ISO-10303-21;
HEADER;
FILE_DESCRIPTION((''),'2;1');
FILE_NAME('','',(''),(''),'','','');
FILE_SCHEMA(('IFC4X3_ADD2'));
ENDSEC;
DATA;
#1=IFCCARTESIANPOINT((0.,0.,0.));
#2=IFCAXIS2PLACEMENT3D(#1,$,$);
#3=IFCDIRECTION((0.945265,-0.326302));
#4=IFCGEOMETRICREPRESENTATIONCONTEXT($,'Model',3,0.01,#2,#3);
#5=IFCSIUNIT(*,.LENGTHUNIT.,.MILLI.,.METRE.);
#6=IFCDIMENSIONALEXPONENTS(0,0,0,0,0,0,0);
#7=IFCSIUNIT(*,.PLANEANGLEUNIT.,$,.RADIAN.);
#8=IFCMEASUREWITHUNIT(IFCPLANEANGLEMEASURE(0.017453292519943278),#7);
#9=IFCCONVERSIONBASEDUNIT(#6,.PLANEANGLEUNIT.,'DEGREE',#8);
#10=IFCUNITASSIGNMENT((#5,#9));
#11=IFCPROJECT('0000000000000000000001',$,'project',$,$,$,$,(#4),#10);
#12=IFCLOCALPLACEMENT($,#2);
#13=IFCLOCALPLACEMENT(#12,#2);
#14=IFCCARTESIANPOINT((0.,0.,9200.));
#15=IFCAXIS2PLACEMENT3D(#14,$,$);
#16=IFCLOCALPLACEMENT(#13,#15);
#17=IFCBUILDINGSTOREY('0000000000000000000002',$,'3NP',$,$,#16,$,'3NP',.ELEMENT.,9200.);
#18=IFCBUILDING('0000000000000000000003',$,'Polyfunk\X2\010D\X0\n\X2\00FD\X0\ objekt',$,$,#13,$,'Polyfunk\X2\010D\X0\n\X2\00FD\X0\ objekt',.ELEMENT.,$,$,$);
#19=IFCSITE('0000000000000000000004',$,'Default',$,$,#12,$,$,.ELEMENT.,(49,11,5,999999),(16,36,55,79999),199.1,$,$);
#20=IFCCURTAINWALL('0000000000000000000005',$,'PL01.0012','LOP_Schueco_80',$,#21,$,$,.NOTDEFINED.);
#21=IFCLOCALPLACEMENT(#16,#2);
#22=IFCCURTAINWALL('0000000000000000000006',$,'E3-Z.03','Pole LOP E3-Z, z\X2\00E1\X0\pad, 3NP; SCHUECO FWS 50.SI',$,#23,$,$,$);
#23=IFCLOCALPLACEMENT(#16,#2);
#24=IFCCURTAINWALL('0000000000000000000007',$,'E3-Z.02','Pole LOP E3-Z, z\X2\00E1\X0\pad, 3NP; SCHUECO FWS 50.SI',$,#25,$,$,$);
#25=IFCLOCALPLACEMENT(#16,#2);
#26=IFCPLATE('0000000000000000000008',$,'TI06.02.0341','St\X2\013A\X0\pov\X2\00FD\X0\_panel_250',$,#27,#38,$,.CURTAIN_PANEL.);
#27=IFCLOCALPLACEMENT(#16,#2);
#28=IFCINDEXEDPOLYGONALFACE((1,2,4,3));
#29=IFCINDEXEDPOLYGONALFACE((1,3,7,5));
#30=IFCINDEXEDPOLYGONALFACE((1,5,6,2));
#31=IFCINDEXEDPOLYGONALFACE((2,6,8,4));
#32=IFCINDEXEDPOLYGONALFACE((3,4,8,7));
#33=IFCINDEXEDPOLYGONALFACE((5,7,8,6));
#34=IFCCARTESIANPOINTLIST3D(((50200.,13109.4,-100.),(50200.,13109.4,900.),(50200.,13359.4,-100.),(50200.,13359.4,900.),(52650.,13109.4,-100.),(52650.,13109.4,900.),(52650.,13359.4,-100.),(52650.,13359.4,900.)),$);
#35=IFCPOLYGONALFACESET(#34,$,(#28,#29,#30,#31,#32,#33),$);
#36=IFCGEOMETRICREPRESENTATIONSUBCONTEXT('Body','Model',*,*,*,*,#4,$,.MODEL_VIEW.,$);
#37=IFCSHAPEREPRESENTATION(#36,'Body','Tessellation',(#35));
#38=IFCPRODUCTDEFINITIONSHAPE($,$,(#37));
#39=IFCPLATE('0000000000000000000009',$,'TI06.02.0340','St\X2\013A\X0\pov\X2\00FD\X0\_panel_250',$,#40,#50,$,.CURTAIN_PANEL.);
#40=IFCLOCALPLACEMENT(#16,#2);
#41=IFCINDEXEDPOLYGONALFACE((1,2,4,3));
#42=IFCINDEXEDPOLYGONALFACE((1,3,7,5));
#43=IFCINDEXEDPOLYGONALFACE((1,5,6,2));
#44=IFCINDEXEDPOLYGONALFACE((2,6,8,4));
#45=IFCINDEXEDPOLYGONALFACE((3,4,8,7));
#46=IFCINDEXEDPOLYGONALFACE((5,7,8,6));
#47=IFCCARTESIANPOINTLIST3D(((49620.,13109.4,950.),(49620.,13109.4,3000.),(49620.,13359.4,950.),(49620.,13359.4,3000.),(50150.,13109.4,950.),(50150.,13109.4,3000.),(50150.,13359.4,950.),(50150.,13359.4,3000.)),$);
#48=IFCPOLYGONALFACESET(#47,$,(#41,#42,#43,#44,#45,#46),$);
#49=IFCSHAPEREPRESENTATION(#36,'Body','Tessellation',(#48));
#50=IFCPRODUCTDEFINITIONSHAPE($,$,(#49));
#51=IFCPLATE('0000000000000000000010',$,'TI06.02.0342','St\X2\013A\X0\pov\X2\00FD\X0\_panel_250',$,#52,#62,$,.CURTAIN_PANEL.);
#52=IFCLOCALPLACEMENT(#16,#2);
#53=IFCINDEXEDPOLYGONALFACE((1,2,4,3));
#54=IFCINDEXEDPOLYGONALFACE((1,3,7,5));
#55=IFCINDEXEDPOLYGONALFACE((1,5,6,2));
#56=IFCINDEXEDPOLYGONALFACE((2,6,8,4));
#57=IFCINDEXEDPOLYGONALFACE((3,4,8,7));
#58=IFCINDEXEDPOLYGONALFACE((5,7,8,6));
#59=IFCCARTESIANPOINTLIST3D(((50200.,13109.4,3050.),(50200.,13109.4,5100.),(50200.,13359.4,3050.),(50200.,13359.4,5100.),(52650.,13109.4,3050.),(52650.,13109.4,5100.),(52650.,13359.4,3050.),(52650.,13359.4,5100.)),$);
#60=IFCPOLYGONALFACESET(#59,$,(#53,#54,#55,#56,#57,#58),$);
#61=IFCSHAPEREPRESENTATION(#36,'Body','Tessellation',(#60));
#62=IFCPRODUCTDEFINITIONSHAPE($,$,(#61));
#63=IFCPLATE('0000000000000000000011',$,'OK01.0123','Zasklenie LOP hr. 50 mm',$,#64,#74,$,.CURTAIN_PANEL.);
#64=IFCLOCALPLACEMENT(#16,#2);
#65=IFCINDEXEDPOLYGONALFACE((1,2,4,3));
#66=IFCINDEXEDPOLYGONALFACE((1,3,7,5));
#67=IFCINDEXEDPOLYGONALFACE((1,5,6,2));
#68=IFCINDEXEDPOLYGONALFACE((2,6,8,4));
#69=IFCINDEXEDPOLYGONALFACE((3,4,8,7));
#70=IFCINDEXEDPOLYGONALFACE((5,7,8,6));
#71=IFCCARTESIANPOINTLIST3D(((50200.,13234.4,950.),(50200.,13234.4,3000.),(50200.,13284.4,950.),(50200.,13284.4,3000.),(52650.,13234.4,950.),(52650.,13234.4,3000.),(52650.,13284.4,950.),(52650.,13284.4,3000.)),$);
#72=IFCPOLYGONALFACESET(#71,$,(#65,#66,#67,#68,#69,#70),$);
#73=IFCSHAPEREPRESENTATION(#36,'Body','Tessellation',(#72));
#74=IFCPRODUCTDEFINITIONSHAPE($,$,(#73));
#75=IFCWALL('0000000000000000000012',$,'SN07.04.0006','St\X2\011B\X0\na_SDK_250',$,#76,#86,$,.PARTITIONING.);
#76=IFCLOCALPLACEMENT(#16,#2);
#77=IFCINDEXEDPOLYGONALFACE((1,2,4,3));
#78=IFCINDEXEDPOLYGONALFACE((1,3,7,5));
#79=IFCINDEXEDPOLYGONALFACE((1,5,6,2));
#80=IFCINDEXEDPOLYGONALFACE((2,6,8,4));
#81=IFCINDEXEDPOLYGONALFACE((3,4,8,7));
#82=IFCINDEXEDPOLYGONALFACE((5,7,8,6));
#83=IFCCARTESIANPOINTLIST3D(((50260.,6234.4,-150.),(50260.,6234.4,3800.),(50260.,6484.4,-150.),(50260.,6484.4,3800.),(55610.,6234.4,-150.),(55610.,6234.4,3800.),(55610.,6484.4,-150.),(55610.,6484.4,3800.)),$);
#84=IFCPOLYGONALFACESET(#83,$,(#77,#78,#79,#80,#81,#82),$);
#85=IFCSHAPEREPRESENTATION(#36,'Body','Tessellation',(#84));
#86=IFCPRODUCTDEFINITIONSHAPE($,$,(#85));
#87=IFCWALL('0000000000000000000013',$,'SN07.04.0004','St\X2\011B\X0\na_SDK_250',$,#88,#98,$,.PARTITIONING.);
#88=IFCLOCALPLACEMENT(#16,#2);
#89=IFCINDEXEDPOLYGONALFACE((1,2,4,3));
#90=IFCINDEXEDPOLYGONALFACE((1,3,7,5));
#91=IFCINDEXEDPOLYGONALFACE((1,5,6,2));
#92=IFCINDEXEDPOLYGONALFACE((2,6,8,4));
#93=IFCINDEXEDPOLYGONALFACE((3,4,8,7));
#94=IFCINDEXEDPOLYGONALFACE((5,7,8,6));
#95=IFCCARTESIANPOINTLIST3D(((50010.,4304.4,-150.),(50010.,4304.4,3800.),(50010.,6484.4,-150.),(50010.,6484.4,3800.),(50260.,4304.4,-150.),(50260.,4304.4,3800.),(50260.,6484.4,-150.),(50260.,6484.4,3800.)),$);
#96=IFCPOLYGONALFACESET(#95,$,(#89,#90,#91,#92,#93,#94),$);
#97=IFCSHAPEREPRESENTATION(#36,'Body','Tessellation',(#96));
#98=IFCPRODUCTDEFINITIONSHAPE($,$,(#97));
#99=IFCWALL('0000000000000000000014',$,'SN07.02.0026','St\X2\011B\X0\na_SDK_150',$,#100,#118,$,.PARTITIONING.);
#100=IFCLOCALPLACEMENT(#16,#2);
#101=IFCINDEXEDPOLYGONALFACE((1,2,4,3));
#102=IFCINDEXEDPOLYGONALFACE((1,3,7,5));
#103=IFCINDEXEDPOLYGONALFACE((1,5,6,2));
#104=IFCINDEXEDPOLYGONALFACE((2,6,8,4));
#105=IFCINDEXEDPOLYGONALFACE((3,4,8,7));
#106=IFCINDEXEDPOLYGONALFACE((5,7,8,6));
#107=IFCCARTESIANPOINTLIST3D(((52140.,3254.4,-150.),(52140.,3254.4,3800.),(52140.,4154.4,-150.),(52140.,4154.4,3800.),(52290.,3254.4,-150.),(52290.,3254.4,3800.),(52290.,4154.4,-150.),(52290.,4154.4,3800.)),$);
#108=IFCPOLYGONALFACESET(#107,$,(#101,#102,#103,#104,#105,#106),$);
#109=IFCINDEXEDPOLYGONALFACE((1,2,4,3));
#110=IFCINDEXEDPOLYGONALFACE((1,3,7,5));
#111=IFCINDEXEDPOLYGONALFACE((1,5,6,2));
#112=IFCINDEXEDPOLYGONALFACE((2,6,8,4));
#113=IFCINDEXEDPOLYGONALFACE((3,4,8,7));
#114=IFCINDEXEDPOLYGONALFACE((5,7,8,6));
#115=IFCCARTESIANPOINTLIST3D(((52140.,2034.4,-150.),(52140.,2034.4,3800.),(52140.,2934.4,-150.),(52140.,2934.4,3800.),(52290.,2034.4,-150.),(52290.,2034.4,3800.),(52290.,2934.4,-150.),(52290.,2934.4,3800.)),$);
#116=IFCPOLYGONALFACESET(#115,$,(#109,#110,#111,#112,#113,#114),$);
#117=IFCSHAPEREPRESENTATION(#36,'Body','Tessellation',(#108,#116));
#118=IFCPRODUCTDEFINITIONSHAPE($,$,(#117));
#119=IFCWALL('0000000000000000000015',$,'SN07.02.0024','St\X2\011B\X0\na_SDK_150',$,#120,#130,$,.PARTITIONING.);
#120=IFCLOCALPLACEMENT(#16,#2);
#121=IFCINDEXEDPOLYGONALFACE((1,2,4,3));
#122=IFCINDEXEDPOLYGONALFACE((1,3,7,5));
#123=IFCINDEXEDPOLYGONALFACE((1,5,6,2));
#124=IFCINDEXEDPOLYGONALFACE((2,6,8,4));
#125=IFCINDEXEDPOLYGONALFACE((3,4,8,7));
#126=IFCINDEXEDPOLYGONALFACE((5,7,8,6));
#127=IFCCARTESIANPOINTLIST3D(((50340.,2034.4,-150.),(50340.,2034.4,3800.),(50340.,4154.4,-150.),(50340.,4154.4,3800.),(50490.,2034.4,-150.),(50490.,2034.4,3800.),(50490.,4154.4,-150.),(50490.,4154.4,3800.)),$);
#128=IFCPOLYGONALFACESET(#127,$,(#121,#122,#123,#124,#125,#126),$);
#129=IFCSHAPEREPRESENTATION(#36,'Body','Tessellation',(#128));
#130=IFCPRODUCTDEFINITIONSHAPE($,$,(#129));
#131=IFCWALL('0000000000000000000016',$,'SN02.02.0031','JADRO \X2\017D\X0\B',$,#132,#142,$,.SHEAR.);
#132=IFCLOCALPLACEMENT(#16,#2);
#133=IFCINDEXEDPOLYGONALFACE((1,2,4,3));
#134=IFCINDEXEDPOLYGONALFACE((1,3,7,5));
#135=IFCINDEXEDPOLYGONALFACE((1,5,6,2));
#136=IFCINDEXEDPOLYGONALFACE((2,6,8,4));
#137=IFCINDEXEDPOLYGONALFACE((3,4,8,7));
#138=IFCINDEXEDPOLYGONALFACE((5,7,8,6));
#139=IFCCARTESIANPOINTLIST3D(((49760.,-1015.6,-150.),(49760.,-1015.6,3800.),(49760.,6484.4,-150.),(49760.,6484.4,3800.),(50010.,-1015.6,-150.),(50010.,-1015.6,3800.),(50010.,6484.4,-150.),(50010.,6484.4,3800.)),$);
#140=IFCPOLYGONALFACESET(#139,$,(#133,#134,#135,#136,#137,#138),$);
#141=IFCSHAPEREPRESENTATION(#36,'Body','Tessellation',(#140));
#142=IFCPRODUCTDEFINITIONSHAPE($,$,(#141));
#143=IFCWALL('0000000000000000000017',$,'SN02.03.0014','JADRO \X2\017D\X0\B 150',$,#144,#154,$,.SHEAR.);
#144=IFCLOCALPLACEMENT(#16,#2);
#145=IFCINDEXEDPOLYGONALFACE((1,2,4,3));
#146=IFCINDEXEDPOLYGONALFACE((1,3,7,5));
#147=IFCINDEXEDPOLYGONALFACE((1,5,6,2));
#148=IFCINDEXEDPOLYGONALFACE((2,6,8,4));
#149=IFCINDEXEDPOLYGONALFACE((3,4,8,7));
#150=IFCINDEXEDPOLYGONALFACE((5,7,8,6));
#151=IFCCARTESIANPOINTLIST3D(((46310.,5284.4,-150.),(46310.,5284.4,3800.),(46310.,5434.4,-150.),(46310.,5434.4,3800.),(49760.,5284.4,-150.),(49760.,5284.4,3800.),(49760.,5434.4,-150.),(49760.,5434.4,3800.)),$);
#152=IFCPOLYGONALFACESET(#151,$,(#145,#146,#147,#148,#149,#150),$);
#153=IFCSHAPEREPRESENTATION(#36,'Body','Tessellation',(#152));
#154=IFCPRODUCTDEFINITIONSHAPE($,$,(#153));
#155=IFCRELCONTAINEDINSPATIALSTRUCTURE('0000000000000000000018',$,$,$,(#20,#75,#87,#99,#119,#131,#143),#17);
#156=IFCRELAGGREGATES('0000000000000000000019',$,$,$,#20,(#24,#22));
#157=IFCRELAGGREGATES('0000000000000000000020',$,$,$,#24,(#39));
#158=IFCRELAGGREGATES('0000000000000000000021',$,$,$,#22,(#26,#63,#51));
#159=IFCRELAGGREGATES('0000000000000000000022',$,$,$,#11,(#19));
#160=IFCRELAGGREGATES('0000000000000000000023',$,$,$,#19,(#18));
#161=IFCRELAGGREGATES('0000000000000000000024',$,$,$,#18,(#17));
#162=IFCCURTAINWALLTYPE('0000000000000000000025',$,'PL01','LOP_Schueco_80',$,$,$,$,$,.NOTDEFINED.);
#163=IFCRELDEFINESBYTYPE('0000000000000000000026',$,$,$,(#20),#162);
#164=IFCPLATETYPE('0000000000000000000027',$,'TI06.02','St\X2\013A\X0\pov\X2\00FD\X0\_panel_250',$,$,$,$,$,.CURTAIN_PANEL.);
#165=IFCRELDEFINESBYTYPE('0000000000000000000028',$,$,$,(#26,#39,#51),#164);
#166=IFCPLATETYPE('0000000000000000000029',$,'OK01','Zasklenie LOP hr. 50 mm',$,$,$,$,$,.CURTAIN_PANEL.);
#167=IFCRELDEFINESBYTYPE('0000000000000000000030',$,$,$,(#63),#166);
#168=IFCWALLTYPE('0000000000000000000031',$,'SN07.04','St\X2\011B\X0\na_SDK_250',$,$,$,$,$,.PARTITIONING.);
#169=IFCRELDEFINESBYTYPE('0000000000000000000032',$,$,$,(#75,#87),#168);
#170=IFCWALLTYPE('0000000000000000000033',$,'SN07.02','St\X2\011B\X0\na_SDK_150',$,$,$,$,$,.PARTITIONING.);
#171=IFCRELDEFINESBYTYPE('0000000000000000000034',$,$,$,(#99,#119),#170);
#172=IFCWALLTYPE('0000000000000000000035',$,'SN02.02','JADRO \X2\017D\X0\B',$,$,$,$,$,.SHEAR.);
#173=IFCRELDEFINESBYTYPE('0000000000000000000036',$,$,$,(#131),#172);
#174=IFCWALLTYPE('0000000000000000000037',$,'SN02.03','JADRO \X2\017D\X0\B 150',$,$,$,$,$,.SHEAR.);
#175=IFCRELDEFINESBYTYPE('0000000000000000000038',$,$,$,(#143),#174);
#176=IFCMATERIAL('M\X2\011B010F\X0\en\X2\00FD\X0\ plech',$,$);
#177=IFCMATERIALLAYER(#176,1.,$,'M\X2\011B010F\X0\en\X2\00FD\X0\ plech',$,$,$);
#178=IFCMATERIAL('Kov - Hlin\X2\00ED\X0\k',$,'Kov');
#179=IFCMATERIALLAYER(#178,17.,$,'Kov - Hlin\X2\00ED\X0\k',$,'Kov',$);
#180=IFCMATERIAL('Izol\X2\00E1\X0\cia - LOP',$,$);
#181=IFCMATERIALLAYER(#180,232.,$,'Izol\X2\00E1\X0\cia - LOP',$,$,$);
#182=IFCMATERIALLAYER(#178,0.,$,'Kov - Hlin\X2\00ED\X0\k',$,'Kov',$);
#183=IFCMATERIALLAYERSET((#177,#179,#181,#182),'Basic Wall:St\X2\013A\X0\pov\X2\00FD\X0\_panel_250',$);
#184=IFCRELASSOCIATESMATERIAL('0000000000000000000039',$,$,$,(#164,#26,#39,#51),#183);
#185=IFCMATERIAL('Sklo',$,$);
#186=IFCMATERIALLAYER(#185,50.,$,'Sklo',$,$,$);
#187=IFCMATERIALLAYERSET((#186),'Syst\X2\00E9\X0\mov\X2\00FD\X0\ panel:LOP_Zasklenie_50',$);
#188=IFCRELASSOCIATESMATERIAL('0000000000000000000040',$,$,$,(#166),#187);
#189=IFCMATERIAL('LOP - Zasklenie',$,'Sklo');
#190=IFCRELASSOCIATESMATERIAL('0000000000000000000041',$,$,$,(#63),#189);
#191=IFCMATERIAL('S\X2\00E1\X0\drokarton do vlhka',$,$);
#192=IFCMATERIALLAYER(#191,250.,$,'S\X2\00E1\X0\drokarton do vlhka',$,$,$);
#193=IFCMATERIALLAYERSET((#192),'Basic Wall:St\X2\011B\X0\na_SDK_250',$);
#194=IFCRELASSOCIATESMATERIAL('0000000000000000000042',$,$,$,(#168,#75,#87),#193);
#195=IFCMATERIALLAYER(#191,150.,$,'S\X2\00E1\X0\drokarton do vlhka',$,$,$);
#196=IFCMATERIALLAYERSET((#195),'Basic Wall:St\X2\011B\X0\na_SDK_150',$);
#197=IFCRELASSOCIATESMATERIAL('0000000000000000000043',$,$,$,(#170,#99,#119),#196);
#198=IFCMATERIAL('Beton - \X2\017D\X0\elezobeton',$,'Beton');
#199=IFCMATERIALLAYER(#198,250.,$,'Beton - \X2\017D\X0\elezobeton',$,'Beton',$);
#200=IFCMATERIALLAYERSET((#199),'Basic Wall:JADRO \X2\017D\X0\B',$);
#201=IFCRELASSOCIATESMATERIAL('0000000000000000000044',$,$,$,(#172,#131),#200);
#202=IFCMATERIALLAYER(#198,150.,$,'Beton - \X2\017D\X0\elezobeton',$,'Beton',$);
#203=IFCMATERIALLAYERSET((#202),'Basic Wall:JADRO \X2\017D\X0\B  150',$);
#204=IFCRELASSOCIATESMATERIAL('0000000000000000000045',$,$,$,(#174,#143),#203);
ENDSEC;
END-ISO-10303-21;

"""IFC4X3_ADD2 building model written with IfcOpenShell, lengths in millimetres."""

from ifc_helpers import new_model, entity, si_unit, converted_unit, direction, frame, frame_2d, origin, origin_2d_with_axis, place, context, subcontext, project, spatial, polyline, rectangle, extrude, clip, bounded_halfspace, source, transform, mapped, material, layer, layer_set, layer_usage, type_object, type_shapes, element, aggregate, save


model = new_model("IFC4X3_ADD2")

# Units and contexts
model_context = context("Model", 3, precision=0.01, world=origin(), true_north=direction((0.945265, -0.326302)))
body_context = subcontext(model_context, "Body", "Model", "MODEL_VIEW")
ifc_project = project(units=[si_unit("LENGTHUNIT", "METRE", prefix="MILLI"), converted_unit("PLANEANGLEUNIT", "DEGREE", entity("IfcPlaneAngleMeasure", 0.017453292519943278), si_unit("PLANEANGLEUNIT", "RADIAN"), dimensions=[0, 0, 0, 0, 0, 0, 0])], contexts=[model_context])

# Site, building, storey
site_placement = place(None, origin())
site = spatial("IfcSite", under=ifc_project, at=site_placement, Name="Default", CompositionType="ELEMENT", RefLatitude=(49, 11, 5, 999999), RefLongitude=(16, 36, 55, 79999), RefElevation=199.1)
building_placement = place(site_placement, origin())
building = spatial("IfcBuilding", under=site, at=building_placement, Name="Polyfunkčný objekt", LongName="Polyfunkčný objekt", CompositionType="ELEMENT")
storey_placement = place(building_placement, frame((0.0, 0.0, 9200.0)))
storey = spatial("IfcBuildingStorey", under=building, at=storey_placement, Name="3NP", LongName="3NP", CompositionType="ELEMENT", Elevation=9200.0)

# Curtain walls, plates
curtain_wall_type = type_object("IfcCurtainWallType", Name="PL01", Description="LOP_Schueco_80", PredefinedType="NOTDEFINED")
curtain_wall_1_placement = place(storey_placement, frame((0.0, 0.0, -9200.0)))
curtain_wall_1 = element("IfcCurtainWall", 1, at=curtain_wall_1_placement, inside=storey, type_object=curtain_wall_type, Name="PL01.0012", Description="LOP_Schueco_80", PredefinedType="NOTDEFINED")
curtain_wall_2 = element("IfcCurtainWall", 2, Name="E3-Z.03", Description="Pole LOP E3-Z, západ, 3NP; SCHUECO FWS 50.SI")
curtain_wall_3 = element("IfcCurtainWall", 3, Name="E3-Z.02", Description="Pole LOP E3-Z, západ, 3NP; SCHUECO FWS 50.SI")
aggregate(curtain_wall_1, [curtain_wall_3, curtain_wall_2])
ifc_material_1 = material(Name="Měďený plech")
ifc_layer_1 = layer(ifc_material_1, 1.0, Name="Měďený plech")
ifc_material_2 = material(Name="Kov - Hliník", Category="Kov")
ifc_layer_2 = layer(ifc_material_2, 17.0, Name="Kov - Hliník", Category="Kov")
ifc_material_3 = material(Name="Izolácia - LOP")
ifc_layer_3 = layer(ifc_material_3, 232.0, Name="Izolácia - LOP")
ifc_layer_4 = layer(ifc_material_2, 0.0, Name="Kov - Hliník", Category="Kov")
ifc_layer_set_1 = layer_set([ifc_layer_1, ifc_layer_2, ifc_layer_3, ifc_layer_4], Name="Basic Wall:Stĺpový_panel_250")
ifc_layer_usage_1 = layer_usage(ifc_layer_set_1, "AXIS2", "NEGATIVE", 125.0)
plate_type_1 = type_object("IfcPlateType", Name="TI06.02", Description="Stĺpový_panel_250", PredefinedType="CURTAIN_PANEL", material=ifc_layer_set_1)
plate_1_placement = place(storey_placement, frame((50200.0, 13234.4, -100.0)))
plate_1 = element("IfcPlate", 4, at=plate_1_placement, type_object=plate_type_1, material=ifc_layer_usage_1, Name="TI06.02.0341", Description="Stĺpový_panel_250", PredefinedType="CURTAIN_PANEL", context=body_context, shape_type="SweptSolid", body=[
    extrude(rectangle(XDim=250.0, YDim=2450.0, at=origin_2d_with_axis()), frame((1225.0, 0.0, 0.0), z_axis=(0.0, 0.0, 1.0), x_axis=(0.0, 1.0, 0.0)), (0.0, 0.0, 1.0), 1000.0),
])
ifc_layer_usage_2 = layer_usage(ifc_layer_set_1, "AXIS2", "NEGATIVE", 125.0)
plate_2_placement = place(storey_placement, frame((49620.0, 13234.4, 950.0)))
plate_2 = element("IfcPlate", 5, at=plate_2_placement, type_object=plate_type_1, material=ifc_layer_usage_2, Name="TI06.02.0340", Description="Stĺpový_panel_250", PredefinedType="CURTAIN_PANEL", context=body_context, shape_type="SweptSolid", body=[
    extrude(rectangle(XDim=250.0, YDim=530.0, at=frame_2d((0.0, 0.0), x_axis=(1.0, 0.0))), frame((265.0, 0.0, 0.0), z_axis=(0.0, 0.0, 1.0), x_axis=(0.0, 1.0, 0.0)), (0.0, 0.0, 1.0), 2050.0),
])
aggregate(curtain_wall_3, [plate_2])
ifc_layer_usage_3 = layer_usage(ifc_layer_set_1, "AXIS2", "NEGATIVE", 125.0)
plate_3_placement = place(storey_placement, frame((50200.0, 13234.4, 3050.0)))
plate_3 = element("IfcPlate", 6, at=plate_3_placement, type_object=plate_type_1, material=ifc_layer_usage_3, Name="TI06.02.0342", Description="Stĺpový_panel_250", PredefinedType="CURTAIN_PANEL", context=body_context, shape_type="SweptSolid", body=[
    extrude(rectangle(XDim=250.0, YDim=2450.0, at=origin_2d_with_axis()), frame((1225.0, 0.0, 0.0), z_axis=(0.0, 0.0, 1.0), x_axis=(0.0, 1.0, 0.0)), (0.0, 0.0, 1.0), 2050.0),
])
ifc_material_4 = material(Name="LOP - Zasklenie", Category="Sklo")
ifc_material_5 = material(Name="Sklo")
ifc_layer_5 = layer(ifc_material_5, 50.0, Name="Sklo")
ifc_layer_set_2 = layer_set([ifc_layer_5], Name="Systémový panel:LOP_Zasklenie_50")
plate_type_2 = type_object("IfcPlateType", Name="OK01", Description="Zasklenie LOP hr. 50 mm", PredefinedType="CURTAIN_PANEL", material=ifc_layer_set_2)
shared_shape_1 = source(origin(), body_context, "Body", "SweptSolid", [
    extrude(rectangle(XDim=50.0, YDim=2450.0, at=origin_2d_with_axis()), frame((0.0, 25.0, 0.0), z_axis=(0.0, 0.0, 1.0), x_axis=(0.0, 1.0, 0.0)), (0.0, 0.0, 1.0), 2050.0),
])
type_shapes(plate_type_2, [shared_shape_1])
plate_4_placement = place(curtain_wall_1_placement, frame((51425.0, 13234.4, 10150.0)))
plate_4 = element("IfcPlate", 7, at=plate_4_placement, type_object=plate_type_2, material=ifc_material_4, Name="OK01.0123", Description="Zasklenie LOP hr. 50 mm", PredefinedType="CURTAIN_PANEL", context=body_context, shape_type="MappedRepresentation", body=[
    mapped(shared_shape_1, transform((0.0, 0.0, 0.0), scale=1.0)),
])
aggregate(curtain_wall_2, [plate_1, plate_4, plate_3])

# Walls
ifc_material_6 = material(Name="Sádrokarton do vlhka")
ifc_layer_6 = layer(ifc_material_6, 250.0, Name="Sádrokarton do vlhka")
ifc_layer_set_3 = layer_set([ifc_layer_6], Name="Basic Wall:Stěna_SDK_250")
wall_type_1 = type_object("IfcWallType", Name="SN07.04", Description="Stěna_SDK_250", PredefinedType="PARTITIONING", material=ifc_layer_set_3)
placement = place(building_placement, frame((0.0, 0.0, 5000.0)))
wall_1_placement = place(placement, frame((50260.0, 6359.4, 4050.0)))
element("IfcWall", 8, at=wall_1_placement, inside=storey, type_object=wall_type_1, material=ifc_layer_set_3, Name="SN07.04.0006", Description="Stěna_SDK_250", PredefinedType="PARTITIONING", context=body_context, shape_type="Clipping", body=[
    clip(clip(extrude(rectangle(XDim=5350.0, YDim=250.0, at=frame_2d((2675.0, 0.0), x_axis=(-1.0, 0.0))), origin(), (0.0, 0.0, 1.0), 3950.0), bounded_halfspace(frame((5350.0, -125.0, 0.0), z_axis=(0.0, 0.0, 1.0), x_axis=(-1.0, 0.0, 0.0)), True, frame((5350.0, -125.0, 0.0)), polyline([(0.0, 0.0), (0.0, 250.0), (-5350.0, 250.0), (-5350.0, 0.0), (-1670.0, 0.0), (-1520.0, 0.0), (0.0, 0.0)]))), bounded_halfspace(frame((0.0, -125.0, 3950.0), z_axis=(0.0, 0.0, -1.0), x_axis=(1.0, 0.0, 0.0)), True, frame((0.0, -125.0, 3950.0)), polyline([(0.0, 0.0), (3680.0, 0.0), (3830.0, 0.0), (5350.0, 0.0), (5350.0, 250.0), (0.0, 250.0), (0.0, 0.0)]))),
])
wall_2_placement = place(placement, frame((50135.0, 6484.4, 4050.0), z_axis=(0.0, 0.0, 1.0), x_axis=(0.0, -1.0, 0.0)))
element("IfcWall", 9, at=wall_2_placement, inside=storey, type_object=wall_type_1, material=ifc_layer_set_3, Name="SN07.04.0004", Description="Stěna_SDK_250", PredefinedType="PARTITIONING", context=body_context, shape_type="Clipping", body=[
    clip(clip(extrude(rectangle(XDim=2180.0, YDim=250.0, at=frame_2d((1090.0, 0.0), x_axis=(-1.0, 0.0))), origin(), (0.0, 0.0, 1.0), 3950.0), bounded_halfspace(frame((2180.0, -125.0, 0.0), z_axis=(0.0, 0.0, 1.0), x_axis=(0.0, -1.0, 0.0)), True, frame((2180.0, -125.0, 0.0)), polyline([(0.0, 0.0), (0.0, 250.0), (-1930.0, 250.0), (-2180.0, 250.0), (-2180.0, 0.0), (0.0, 0.0)]))), bounded_halfspace(frame((0.0, -125.0, 3950.0), z_axis=(0.0, 0.0, -1.0), x_axis=(0.0, 1.0, 0.0)), True, frame((0.0, -125.0, 3950.0)), polyline([(0.0, 0.0), (2180.0, 0.0), (2180.0, 250.0), (250.0, 250.0), (0.0, 250.0), (0.0, 0.0)]))),
])
ifc_layer_7 = layer(ifc_material_6, 150.0, Name="Sádrokarton do vlhka")
ifc_layer_set_4 = layer_set([ifc_layer_7], Name="Basic Wall:Stěna_SDK_150")
wall_type_2 = type_object("IfcWallType", Name="SN07.02", Description="Stěna_SDK_150", PredefinedType="PARTITIONING", material=ifc_layer_set_4)
wall_3_placement = place(placement, frame((52215.0, 4154.4, 4050.0), z_axis=(0.0, 0.0, 1.0), x_axis=(0.0, -1.0, 0.0)))
element("IfcWall", 10, at=wall_3_placement, inside=storey, type_object=wall_type_2, material=ifc_layer_set_4, Name="SN07.02.0026", Description="Stěna_SDK_150", PredefinedType="PARTITIONING", context=body_context, shape_type="SweptSolid", body=[
    extrude(rectangle(XDim=900.0, YDim=150.0, at=frame_2d((0.0, 0.0), x_axis=(1.0, 0.0))), frame((450.0, 0.0, 0.0)), (0.0, 0.0, 1.0), 3950.0),
    extrude(rectangle(XDim=900.0, YDim=150.0, at=frame_2d((0.0, 0.0), x_axis=(1.0, 0.0))), frame((1670.0, 0.0, 0.0), z_axis=(0.0, 0.0, 1.0), x_axis=(-1.0, 0.0, 0.0)), (0.0, 0.0, 1.0), 3950.0),
])
wall_4_placement = place(placement, frame((50415.0, 4154.4, 4050.0), z_axis=(0.0, 0.0, 1.0), x_axis=(0.0, -1.0, 0.0)))
element("IfcWall", 11, at=wall_4_placement, inside=storey, type_object=wall_type_2, material=ifc_layer_set_4, Name="SN07.02.0024", Description="Stěna_SDK_150", PredefinedType="PARTITIONING", context=body_context, shape_type="Clipping", body=[
    clip(clip(extrude(rectangle(XDim=2120.0, YDim=150.0, at=frame_2d((1060.0, 0.0), x_axis=(-1.0, 0.0))), origin(), (0.0, 0.0, 1.0), 3950.0), bounded_halfspace(frame((2120.0, -75.0, 0.0), z_axis=(0.0, 0.0, 1.0), x_axis=(0.0, -1.0, 0.0)), True, frame((2120.0, -75.0, 0.0)), polyline([(0.0, 0.0), (0.0, 150.0), (-900.0, 150.0), (-1220.0, 150.0), (-2120.0, 150.0), (-2120.0, 0.0), (0.0, 0.0)]))), bounded_halfspace(frame((0.0, -75.0, 3950.0), z_axis=(0.0, 0.0, -1.0), x_axis=(0.0, 1.0, 0.0)), True, frame((0.0, -75.0, 3950.0)), polyline([(0.0, 0.0), (2120.0, 0.0), (2120.0, 150.0), (1220.0, 150.0), (900.0, 150.0), (0.0, 150.0), (0.0, 0.0)]))),
])
ifc_material_7 = material(Name="Beton - Železobeton", Category="Beton")
ifc_layer_8 = layer(ifc_material_7, 250.0, Name="Beton - Železobeton", Category="Beton")
ifc_layer_set_5 = layer_set([ifc_layer_8], Name="Basic Wall:JADRO ŽB")
wall_type_3 = type_object("IfcWallType", Name="SN02.02", Description="JADRO ŽB", PredefinedType="SHEAR", material=ifc_layer_set_5)
wall_5_placement = place(placement, frame((49885.0, 6484.4, 4050.0), z_axis=(0.0, 0.0, 1.0), x_axis=(0.0, -1.0, 0.0)))
element("IfcWall", 12, at=wall_5_placement, inside=storey, type_object=wall_type_3, material=ifc_layer_set_5, Name="SN02.02.0031", Description="JADRO ŽB", PredefinedType="SHEAR", context=body_context, shape_type="Clipping", body=[
    clip(clip(extrude(rectangle(XDim=7500.0, YDim=250.0, at=frame_2d((3750.0, 0.0), x_axis=(-1.0, 0.0))), origin(), (0.0, 0.0, 1.0), 3950.0), bounded_halfspace(frame((7500.0, -125.0, 0.0), z_axis=(0.0, 0.0, 1.0), x_axis=(0.0, -1.0, 0.0)), True, frame((7500.0, -125.0, 0.0)), polyline([(0.0, 0.0), (0.0, 250.0), (-7500.0, 250.0), (-7500.0, 0.0), (-7250.0, 0.0), (-6450.0, 0.0), (-6300.0, 0.0), (0.0, 0.0)]))), bounded_halfspace(frame((0.0, -125.0, 3950.0), z_axis=(0.0, 0.0, -1.0), x_axis=(0.0, 1.0, 0.0)), True, frame((0.0, -125.0, 3950.0)), polyline([(0.0, 0.0), (250.0, 0.0), (1050.0, 0.0), (1200.0, 0.0), (7500.0, 0.0), (7500.0, 250.0), (0.0, 250.0), (0.0, 0.0)]))),
])
ifc_layer_9 = layer(ifc_material_7, 150.0, Name="Beton - Železobeton", Category="Beton")
ifc_layer_set_6 = layer_set([ifc_layer_9], Name="Basic Wall:JADRO ŽB  150")
wall_type_4 = type_object("IfcWallType", Name="SN02.03", Description="JADRO ŽB 150", PredefinedType="SHEAR", material=ifc_layer_set_6)
wall_6_placement = place(placement, frame((46310.0, 5359.4, 4050.0)))
element("IfcWall", 13, at=wall_6_placement, inside=storey, type_object=wall_type_4, material=ifc_layer_set_6, Name="SN02.03.0014", Description="JADRO ŽB 150", PredefinedType="SHEAR", context=body_context, shape_type="SweptSolid", body=[
    extrude(rectangle(XDim=3450.0, YDim=150.0, at=frame_2d((1725.0, 0.0), x_axis=(-1.0, 0.0))), origin(), (0.0, 0.0, 1.0), 3950.0),
])

save(model, "model.ifc")
